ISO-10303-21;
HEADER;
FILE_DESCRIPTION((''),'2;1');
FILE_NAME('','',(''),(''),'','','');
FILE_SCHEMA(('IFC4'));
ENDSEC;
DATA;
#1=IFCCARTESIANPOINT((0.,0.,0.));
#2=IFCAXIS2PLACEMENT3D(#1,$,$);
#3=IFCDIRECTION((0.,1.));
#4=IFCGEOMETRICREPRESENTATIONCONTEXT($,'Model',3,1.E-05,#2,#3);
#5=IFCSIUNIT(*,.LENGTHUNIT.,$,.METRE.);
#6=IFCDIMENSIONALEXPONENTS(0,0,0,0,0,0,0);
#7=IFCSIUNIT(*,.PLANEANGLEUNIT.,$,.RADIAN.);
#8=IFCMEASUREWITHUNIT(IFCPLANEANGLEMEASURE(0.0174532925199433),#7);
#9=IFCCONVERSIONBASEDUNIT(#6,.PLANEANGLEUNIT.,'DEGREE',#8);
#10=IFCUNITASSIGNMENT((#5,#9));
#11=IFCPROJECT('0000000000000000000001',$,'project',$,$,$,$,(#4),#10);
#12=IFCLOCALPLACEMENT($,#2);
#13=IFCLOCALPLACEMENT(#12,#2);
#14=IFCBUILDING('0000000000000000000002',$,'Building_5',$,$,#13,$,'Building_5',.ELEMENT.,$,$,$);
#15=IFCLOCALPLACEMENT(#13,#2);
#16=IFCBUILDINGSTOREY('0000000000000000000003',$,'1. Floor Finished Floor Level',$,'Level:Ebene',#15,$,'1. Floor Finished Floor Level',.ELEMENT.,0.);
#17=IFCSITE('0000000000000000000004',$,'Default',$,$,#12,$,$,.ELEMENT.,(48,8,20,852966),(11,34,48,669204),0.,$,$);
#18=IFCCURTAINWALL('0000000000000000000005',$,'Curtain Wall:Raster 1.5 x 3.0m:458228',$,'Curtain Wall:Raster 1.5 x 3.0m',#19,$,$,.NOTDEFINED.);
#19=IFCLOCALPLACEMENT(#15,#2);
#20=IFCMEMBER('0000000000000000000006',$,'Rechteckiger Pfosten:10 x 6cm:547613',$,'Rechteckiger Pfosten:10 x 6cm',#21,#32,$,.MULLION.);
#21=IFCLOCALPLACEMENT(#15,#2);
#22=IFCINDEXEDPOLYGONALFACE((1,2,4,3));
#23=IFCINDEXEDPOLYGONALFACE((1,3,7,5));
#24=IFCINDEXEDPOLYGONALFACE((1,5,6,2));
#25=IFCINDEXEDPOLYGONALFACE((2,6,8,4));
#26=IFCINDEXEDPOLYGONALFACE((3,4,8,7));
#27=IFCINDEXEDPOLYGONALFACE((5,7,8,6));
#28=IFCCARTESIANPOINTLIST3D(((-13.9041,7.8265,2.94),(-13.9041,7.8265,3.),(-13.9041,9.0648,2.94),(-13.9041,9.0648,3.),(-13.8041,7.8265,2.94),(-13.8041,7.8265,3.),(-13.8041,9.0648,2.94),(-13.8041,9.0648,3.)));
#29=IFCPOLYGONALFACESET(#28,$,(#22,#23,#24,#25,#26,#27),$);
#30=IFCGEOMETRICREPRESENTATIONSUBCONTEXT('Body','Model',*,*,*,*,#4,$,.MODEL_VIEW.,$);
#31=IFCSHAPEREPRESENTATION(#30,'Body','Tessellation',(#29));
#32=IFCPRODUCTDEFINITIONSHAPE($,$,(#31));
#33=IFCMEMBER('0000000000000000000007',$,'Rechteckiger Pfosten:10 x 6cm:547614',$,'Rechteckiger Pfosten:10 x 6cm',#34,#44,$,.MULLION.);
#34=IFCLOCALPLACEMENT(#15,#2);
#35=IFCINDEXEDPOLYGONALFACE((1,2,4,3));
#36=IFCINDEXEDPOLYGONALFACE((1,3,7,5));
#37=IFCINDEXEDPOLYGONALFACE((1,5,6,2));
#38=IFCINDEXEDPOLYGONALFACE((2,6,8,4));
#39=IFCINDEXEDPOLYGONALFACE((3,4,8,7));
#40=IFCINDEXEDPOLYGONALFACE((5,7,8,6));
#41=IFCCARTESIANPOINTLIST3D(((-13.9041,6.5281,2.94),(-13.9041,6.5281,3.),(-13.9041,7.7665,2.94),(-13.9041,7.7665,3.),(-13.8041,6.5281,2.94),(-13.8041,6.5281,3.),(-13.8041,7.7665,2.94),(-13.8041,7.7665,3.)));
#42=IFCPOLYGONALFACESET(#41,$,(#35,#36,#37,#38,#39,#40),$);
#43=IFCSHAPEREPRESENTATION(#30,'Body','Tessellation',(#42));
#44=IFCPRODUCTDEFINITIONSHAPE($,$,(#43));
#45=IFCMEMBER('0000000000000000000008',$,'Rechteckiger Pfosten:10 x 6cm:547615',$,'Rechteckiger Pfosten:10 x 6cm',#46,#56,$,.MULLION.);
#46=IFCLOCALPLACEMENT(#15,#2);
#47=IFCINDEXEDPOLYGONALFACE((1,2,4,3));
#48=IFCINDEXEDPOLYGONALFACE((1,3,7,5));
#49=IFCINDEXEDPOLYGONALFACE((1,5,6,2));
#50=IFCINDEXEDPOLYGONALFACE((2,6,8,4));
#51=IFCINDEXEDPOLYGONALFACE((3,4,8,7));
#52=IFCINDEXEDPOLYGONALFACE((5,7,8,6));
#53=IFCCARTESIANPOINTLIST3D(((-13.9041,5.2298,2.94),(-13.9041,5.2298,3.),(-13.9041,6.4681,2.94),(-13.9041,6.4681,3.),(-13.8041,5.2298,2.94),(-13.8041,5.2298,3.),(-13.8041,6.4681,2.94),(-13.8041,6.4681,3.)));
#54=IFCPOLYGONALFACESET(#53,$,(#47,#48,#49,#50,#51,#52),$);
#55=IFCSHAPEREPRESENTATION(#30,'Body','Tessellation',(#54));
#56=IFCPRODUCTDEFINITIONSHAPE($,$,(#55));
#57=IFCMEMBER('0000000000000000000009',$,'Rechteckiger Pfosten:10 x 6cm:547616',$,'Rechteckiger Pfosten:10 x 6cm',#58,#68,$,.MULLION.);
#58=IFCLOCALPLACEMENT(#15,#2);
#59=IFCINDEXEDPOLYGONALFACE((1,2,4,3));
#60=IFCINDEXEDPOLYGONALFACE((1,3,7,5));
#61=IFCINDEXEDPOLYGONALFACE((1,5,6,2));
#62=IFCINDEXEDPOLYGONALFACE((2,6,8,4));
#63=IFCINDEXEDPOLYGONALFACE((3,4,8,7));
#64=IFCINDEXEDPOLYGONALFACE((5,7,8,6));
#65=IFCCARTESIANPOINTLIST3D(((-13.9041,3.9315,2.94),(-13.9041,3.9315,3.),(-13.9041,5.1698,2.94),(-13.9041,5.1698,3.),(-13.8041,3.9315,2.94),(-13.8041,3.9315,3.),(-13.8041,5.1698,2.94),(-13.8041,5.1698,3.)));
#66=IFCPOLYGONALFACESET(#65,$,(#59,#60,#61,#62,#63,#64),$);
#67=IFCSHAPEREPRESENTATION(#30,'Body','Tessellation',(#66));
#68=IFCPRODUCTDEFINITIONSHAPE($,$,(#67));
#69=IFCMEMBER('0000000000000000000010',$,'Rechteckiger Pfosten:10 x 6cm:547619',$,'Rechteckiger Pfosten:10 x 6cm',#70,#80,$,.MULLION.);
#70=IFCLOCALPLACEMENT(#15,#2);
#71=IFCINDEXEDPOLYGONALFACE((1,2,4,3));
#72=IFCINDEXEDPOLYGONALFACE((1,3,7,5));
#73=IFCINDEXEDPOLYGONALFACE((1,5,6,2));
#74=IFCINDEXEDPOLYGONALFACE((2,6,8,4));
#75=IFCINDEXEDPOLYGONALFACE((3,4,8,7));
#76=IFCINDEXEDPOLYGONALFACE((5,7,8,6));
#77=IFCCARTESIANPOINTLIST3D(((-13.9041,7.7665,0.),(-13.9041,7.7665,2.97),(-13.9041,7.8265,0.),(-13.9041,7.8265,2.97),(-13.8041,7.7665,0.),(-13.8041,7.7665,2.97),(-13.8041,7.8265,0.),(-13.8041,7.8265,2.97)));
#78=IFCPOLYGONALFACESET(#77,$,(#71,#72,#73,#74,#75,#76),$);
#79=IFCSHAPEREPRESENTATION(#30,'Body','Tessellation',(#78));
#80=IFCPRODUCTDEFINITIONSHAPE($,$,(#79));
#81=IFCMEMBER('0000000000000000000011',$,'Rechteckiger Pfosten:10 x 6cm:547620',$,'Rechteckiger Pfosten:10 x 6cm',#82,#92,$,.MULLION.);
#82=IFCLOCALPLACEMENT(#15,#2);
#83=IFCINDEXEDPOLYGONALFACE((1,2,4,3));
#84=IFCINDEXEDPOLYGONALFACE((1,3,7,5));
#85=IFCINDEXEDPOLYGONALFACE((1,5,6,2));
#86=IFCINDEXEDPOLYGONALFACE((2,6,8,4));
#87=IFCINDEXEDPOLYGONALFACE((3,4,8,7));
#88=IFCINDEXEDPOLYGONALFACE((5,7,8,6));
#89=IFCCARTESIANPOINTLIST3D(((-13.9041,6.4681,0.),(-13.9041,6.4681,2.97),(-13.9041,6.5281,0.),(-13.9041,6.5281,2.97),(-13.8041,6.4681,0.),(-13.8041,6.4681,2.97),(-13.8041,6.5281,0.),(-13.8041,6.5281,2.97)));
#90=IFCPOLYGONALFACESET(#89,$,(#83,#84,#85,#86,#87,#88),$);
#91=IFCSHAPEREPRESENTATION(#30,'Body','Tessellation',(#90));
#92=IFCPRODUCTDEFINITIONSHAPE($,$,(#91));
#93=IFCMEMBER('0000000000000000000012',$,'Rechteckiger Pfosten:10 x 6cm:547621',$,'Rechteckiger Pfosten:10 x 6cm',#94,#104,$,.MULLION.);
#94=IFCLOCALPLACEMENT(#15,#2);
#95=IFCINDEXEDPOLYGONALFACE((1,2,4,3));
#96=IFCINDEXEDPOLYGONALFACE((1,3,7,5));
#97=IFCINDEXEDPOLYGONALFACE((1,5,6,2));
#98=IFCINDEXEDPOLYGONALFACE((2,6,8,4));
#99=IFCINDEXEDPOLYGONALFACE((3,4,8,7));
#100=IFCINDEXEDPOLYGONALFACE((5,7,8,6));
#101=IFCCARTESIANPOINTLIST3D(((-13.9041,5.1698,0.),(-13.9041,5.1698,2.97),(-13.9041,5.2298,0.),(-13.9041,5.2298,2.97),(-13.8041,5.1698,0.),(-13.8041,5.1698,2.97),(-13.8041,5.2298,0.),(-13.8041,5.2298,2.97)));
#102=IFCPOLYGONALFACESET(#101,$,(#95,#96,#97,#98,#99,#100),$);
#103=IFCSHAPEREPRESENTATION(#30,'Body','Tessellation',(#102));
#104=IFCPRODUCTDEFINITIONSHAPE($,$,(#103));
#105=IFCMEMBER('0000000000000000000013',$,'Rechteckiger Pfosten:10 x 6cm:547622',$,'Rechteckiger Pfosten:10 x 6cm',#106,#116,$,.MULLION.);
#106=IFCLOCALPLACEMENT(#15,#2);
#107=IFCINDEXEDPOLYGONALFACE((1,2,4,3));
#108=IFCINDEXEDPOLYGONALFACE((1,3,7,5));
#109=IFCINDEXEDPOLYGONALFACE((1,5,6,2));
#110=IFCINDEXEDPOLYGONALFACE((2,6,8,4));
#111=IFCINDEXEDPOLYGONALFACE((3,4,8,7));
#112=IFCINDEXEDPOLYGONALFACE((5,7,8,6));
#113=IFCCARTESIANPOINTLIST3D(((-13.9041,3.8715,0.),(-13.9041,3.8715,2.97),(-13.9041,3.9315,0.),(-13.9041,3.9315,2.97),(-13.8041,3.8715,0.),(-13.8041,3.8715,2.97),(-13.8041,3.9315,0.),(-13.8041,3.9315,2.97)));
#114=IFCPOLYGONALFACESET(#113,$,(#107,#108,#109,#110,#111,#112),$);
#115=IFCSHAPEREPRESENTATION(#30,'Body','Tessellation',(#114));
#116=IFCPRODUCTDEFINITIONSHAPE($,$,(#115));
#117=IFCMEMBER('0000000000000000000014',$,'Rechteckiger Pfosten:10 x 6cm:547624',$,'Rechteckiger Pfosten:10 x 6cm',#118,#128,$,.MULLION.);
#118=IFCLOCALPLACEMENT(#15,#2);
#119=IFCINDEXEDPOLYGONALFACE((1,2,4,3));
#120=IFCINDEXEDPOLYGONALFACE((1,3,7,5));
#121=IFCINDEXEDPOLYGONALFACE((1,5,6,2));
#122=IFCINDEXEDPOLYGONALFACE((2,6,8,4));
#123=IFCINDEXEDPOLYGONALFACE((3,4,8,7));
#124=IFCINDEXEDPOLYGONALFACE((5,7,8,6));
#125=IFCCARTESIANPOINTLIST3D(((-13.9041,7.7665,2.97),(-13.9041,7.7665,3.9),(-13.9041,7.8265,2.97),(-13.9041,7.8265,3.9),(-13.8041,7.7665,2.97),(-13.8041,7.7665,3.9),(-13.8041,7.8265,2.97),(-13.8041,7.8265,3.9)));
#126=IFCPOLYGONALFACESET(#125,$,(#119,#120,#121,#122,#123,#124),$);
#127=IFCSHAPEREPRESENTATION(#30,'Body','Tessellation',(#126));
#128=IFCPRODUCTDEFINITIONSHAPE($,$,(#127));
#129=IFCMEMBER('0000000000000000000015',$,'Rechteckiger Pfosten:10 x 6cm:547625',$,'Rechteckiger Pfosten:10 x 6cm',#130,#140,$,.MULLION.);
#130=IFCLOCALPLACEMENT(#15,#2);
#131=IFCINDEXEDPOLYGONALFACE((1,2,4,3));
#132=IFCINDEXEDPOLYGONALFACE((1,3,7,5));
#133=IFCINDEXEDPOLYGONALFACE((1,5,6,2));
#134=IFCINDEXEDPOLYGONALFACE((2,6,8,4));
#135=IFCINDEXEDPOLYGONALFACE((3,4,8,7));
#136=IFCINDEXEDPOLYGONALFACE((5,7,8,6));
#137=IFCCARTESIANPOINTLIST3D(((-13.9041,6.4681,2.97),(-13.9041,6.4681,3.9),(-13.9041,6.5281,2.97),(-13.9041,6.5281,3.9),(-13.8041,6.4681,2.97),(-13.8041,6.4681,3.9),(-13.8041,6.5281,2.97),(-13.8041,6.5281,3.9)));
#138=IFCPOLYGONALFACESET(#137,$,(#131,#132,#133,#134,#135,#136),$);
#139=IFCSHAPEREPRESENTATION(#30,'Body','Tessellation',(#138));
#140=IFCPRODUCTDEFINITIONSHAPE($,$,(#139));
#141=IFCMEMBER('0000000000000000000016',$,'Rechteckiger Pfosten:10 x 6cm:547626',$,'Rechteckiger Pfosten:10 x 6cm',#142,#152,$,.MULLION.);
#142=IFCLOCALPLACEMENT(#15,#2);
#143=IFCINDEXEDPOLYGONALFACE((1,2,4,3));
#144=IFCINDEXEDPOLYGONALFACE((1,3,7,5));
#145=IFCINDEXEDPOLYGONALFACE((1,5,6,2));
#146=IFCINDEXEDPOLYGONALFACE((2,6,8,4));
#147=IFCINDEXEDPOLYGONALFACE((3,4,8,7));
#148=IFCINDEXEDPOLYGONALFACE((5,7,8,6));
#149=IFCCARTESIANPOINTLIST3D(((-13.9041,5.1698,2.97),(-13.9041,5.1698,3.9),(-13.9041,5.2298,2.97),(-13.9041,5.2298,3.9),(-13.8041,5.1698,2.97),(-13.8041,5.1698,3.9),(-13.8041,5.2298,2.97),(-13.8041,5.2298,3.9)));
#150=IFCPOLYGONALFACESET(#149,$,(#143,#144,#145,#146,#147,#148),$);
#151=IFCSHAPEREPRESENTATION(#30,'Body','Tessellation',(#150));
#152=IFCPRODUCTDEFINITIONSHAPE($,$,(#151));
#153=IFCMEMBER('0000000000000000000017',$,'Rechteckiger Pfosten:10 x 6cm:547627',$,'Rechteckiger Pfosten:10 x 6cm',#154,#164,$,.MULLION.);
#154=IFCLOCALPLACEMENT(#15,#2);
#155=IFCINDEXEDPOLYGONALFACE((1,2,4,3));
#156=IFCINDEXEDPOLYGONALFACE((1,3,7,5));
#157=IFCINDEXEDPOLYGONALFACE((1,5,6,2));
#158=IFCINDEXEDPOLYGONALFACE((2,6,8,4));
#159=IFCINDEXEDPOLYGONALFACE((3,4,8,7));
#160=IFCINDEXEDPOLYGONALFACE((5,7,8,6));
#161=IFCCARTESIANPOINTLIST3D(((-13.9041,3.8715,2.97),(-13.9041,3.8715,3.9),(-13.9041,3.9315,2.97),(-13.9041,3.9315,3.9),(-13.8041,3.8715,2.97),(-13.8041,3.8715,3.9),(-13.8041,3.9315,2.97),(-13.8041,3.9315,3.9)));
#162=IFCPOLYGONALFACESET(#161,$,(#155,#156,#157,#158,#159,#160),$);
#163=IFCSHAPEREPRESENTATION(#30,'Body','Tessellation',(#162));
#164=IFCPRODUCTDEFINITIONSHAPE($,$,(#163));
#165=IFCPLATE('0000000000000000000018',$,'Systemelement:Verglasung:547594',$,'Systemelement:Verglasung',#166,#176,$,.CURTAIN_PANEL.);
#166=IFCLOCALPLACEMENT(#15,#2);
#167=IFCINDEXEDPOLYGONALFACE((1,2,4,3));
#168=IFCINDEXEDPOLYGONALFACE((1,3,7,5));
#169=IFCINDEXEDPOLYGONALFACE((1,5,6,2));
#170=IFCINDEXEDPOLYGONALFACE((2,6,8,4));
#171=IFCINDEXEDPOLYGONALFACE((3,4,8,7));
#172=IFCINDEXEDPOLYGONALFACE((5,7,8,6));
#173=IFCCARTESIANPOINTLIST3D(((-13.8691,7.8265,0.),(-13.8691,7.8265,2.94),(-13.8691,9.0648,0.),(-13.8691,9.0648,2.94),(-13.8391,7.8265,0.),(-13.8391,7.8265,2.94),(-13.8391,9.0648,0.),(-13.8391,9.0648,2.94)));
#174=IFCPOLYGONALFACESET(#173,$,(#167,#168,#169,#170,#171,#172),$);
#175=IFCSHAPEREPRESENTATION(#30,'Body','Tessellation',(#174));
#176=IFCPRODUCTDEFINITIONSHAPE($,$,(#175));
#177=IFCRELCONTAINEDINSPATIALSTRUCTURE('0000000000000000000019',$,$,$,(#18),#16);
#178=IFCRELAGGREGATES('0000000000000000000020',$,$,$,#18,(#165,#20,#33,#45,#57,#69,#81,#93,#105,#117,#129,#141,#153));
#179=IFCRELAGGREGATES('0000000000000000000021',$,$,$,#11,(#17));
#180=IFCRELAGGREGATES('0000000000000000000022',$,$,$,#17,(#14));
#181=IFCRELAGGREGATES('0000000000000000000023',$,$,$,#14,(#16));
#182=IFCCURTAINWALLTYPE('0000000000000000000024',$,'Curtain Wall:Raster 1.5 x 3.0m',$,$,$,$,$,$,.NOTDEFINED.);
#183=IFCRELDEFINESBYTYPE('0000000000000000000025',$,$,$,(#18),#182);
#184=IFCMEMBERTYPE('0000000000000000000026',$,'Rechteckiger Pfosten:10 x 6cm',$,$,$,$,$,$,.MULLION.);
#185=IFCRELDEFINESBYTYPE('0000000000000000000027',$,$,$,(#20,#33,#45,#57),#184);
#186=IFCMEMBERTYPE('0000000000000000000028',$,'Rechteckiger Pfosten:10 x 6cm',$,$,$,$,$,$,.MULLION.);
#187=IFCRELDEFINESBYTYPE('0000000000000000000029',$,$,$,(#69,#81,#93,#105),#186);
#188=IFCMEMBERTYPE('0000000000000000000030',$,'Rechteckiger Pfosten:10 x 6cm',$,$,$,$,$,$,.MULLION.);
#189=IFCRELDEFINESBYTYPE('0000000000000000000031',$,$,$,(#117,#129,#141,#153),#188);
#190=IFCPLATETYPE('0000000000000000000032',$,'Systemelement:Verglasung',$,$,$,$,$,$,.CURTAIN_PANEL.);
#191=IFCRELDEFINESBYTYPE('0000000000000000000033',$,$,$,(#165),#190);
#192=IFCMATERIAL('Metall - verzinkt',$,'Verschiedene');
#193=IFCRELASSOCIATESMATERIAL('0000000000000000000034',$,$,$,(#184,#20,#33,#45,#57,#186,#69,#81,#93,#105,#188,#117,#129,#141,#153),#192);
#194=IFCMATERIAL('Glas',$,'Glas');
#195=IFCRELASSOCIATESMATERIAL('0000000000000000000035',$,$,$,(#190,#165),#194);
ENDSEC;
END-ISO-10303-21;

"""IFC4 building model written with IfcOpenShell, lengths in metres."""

from ifc_helpers import new_model, entity, si_unit, converted_unit, direction, frame, origin, place, context, subcontext, project, spatial, indexed_curve, outline, extrude, source, transform, mapped, material, type_object, type_shapes, element, aggregate, save


model = new_model("IFC4")

# Units and contexts
model_context = context("Model", 3, precision=1e-05, world=origin(), true_north=direction((0.0, 1.0)))
body_context = subcontext(model_context, "Body", "Model", "MODEL_VIEW")
ifc_project = project(units=[si_unit("LENGTHUNIT", "METRE"), converted_unit("PLANEANGLEUNIT", "DEGREE", entity("IfcPlaneAngleMeasure", 0.0174532925199433), si_unit("PLANEANGLEUNIT", "RADIAN"), dimensions=[0, 0, 0, 0, 0, 0, 0])], contexts=[model_context])

# Site, building, storey
site_placement = place(None, origin())
site = spatial("IfcSite", under=ifc_project, at=site_placement, Name="Default", CompositionType="ELEMENT", RefLatitude=(48, 8, 20, 852966), RefLongitude=(11, 34, 48, 669204), RefElevation=0.0)
building_placement = place(site_placement, origin())
building = spatial("IfcBuilding", under=site, at=building_placement, Name="Building_5", LongName="Building_5", CompositionType="ELEMENT")
storey_placement = place(building_placement, origin())
storey = spatial("IfcBuildingStorey", under=building, at=storey_placement, Name="1. Floor Finished Floor Level", ObjectType="Level:Ebene", LongName="1. Floor Finished Floor Level", CompositionType="ELEMENT", Elevation=0.0)

# Curtain wall, members, plate
curtain_wall_type = type_object("IfcCurtainWallType", Name="Curtain Wall:Raster 1.5 x 3.0m", PredefinedType="NOTDEFINED")
curtain_wall_placement = place(storey_placement, origin())
curtain_wall = element("IfcCurtainWall", 1, at=curtain_wall_placement, inside=storey, type_object=curtain_wall_type, Name="Curtain Wall:Raster 1.5 x 3.0m:458228", ObjectType="Curtain Wall:Raster 1.5 x 3.0m", PredefinedType="NOTDEFINED")
ifc_material_1 = material(Name="Metall - verzinkt", Category="Verschiedene")
member_type_1 = type_object("IfcMemberType", Name="Rechteckiger Pfosten:10 x 6cm", PredefinedType="MULLION", material=ifc_material_1)
shared_shape_1 = source(origin(), body_context, "Body", "SweptSolid", [
    extrude(outline(indexed_curve([(-0.03, -0.05), (0.03, -0.05), (0.03, 0.05), (-0.03, 0.05), (-0.03, -0.05)], self_intersect=False)), frame((0.0, 0.0, -1.2383), z_axis=(0.0, 0.0, 1.0), x_axis=(-1.0, 0.0, 0.0)), (0.0, 0.0, 1.0), 1.2383),
])
type_shapes(member_type_1, [shared_shape_1])
member_1_placement = place(curtain_wall_placement, frame((-13.8541, 7.8265, 2.97), z_axis=(0.0, -1.0, 0.0), x_axis=(0.0, 0.0, 1.0)))
member_1 = element("IfcMember", 2, at=member_1_placement, type_object=member_type_1, material=ifc_material_1, Name="Rechteckiger Pfosten:10 x 6cm:547613", ObjectType="Rechteckiger Pfosten:10 x 6cm", PredefinedType="MULLION", context=body_context, shape_type="MappedRepresentation", body=[
    mapped(shared_shape_1, transform((0.0, 0.0, 0.0), scale=1.0)),
])
member_2_placement = place(curtain_wall_placement, frame((-13.8541, 6.5281, 2.97), z_axis=(0.0, -1.0, 0.0), x_axis=(0.0, 0.0, 1.0)))
member_2 = element("IfcMember", 3, at=member_2_placement, type_object=member_type_1, material=ifc_material_1, Name="Rechteckiger Pfosten:10 x 6cm:547614", ObjectType="Rechteckiger Pfosten:10 x 6cm", PredefinedType="MULLION", context=body_context, shape_type="MappedRepresentation", body=[
    mapped(shared_shape_1, transform((0.0, 0.0, 0.0), scale=1.0)),
])
member_3_placement = place(curtain_wall_placement, frame((-13.8541, 5.2298, 2.97), z_axis=(0.0, -1.0, 0.0), x_axis=(0.0, 0.0, 1.0)))
member_3 = element("IfcMember", 4, at=member_3_placement, type_object=member_type_1, material=ifc_material_1, Name="Rechteckiger Pfosten:10 x 6cm:547615", ObjectType="Rechteckiger Pfosten:10 x 6cm", PredefinedType="MULLION", context=body_context, shape_type="MappedRepresentation", body=[
    mapped(shared_shape_1, transform((0.0, 0.0, 0.0), scale=1.0)),
])
member_4_placement = place(curtain_wall_placement, frame((-13.8541, 3.9315, 2.97), z_axis=(0.0, -1.0, 0.0), x_axis=(0.0, 0.0, 1.0)))
member_4 = element("IfcMember", 5, at=member_4_placement, type_object=member_type_1, material=ifc_material_1, Name="Rechteckiger Pfosten:10 x 6cm:547616", ObjectType="Rechteckiger Pfosten:10 x 6cm", PredefinedType="MULLION", context=body_context, shape_type="MappedRepresentation", body=[
    mapped(shared_shape_1, transform((0.0, 0.0, 0.0), scale=1.0)),
])
member_type_2 = type_object("IfcMemberType", Name="Rechteckiger Pfosten:10 x 6cm", PredefinedType="MULLION", material=ifc_material_1)
shared_shape_2 = source(origin(), body_context, "Body", "SweptSolid", [
    extrude(outline(indexed_curve([(-0.03, -0.05), (0.03, -0.05), (0.03, 0.05), (-0.03, 0.05), (-0.03, -0.05)], self_intersect=False)), frame((0.0, 0.0, -2.97), z_axis=(0.0, 0.0, 1.0), x_axis=(-1.0, 0.0, 0.0)), (0.0, 0.0, 1.0), 2.97),
])
type_shapes(member_type_2, [shared_shape_2])
member_5_placement = place(curtain_wall_placement, frame((-13.8541, 7.7965, 0.0), z_axis=(0.0, 0.0, -1.0), x_axis=(0.0, -1.0, 0.0)))
member_5 = element("IfcMember", 6, at=member_5_placement, type_object=member_type_2, material=ifc_material_1, Name="Rechteckiger Pfosten:10 x 6cm:547619", ObjectType="Rechteckiger Pfosten:10 x 6cm", PredefinedType="MULLION", context=body_context, shape_type="MappedRepresentation", body=[
    mapped(shared_shape_2, transform((0.0, 0.0, 0.0), scale=1.0)),
])
member_6_placement = place(curtain_wall_placement, frame((-13.8541, 6.4981, 0.0), z_axis=(0.0, 0.0, -1.0), x_axis=(0.0, -1.0, 0.0)))
member_6 = element("IfcMember", 7, at=member_6_placement, type_object=member_type_2, material=ifc_material_1, Name="Rechteckiger Pfosten:10 x 6cm:547620", ObjectType="Rechteckiger Pfosten:10 x 6cm", PredefinedType="MULLION", context=body_context, shape_type="MappedRepresentation", body=[
    mapped(shared_shape_2, transform((0.0, 0.0, 0.0), scale=1.0)),
])
member_7_placement = place(curtain_wall_placement, frame((-13.8541, 5.1998, 0.0), z_axis=(0.0, 0.0, -1.0), x_axis=(0.0, -1.0, 0.0)))
member_7 = element("IfcMember", 8, at=member_7_placement, type_object=member_type_2, material=ifc_material_1, Name="Rechteckiger Pfosten:10 x 6cm:547621", ObjectType="Rechteckiger Pfosten:10 x 6cm", PredefinedType="MULLION", context=body_context, shape_type="MappedRepresentation", body=[
    mapped(shared_shape_2, transform((0.0, 0.0, 0.0), scale=1.0)),
])
member_8_placement = place(curtain_wall_placement, frame((-13.8541, 3.9015, 0.0), z_axis=(0.0, 0.0, -1.0), x_axis=(0.0, -1.0, 0.0)))
member_8 = element("IfcMember", 9, at=member_8_placement, type_object=member_type_2, material=ifc_material_1, Name="Rechteckiger Pfosten:10 x 6cm:547622", ObjectType="Rechteckiger Pfosten:10 x 6cm", PredefinedType="MULLION", context=body_context, shape_type="MappedRepresentation", body=[
    mapped(shared_shape_2, transform((0.0, 0.0, 0.0), scale=1.0)),
])
member_type_3 = type_object("IfcMemberType", Name="Rechteckiger Pfosten:10 x 6cm", PredefinedType="MULLION", material=ifc_material_1)
shared_shape_3 = source(origin(), body_context, "Body", "SweptSolid", [
    extrude(outline(indexed_curve([(-0.03, -0.05), (0.03, -0.05), (0.03, 0.05), (-0.03, 0.05), (-0.03, -0.05)], self_intersect=False)), frame((0.0, 0.0, -0.93), z_axis=(0.0, 0.0, 1.0), x_axis=(-1.0, 0.0, 0.0)), (0.0, 0.0, 1.0), 0.93),
])
type_shapes(member_type_3, [shared_shape_3])
member_9_placement = place(curtain_wall_placement, frame((-13.8541, 7.7965, 2.97), z_axis=(0.0, 0.0, -1.0), x_axis=(0.0, -1.0, 0.0)))
member_9 = element("IfcMember", 10, at=member_9_placement, type_object=member_type_3, material=ifc_material_1, Name="Rechteckiger Pfosten:10 x 6cm:547624", ObjectType="Rechteckiger Pfosten:10 x 6cm", PredefinedType="MULLION", context=body_context, shape_type="MappedRepresentation", body=[
    mapped(shared_shape_3, transform((0.0, 0.0, 0.0), scale=1.0)),
])
member_10_placement = place(curtain_wall_placement, frame((-13.8541, 6.4981, 2.97), z_axis=(0.0, 0.0, -1.0), x_axis=(0.0, -1.0, 0.0)))
member_10 = element("IfcMember", 11, at=member_10_placement, type_object=member_type_3, material=ifc_material_1, Name="Rechteckiger Pfosten:10 x 6cm:547625", ObjectType="Rechteckiger Pfosten:10 x 6cm", PredefinedType="MULLION", context=body_context, shape_type="MappedRepresentation", body=[
    mapped(shared_shape_3, transform((0.0, 0.0, 0.0), scale=1.0)),
])
member_11_placement = place(curtain_wall_placement, frame((-13.8541, 5.1998, 2.97), z_axis=(0.0, 0.0, -1.0), x_axis=(0.0, -1.0, 0.0)))
member_11 = element("IfcMember", 12, at=member_11_placement, type_object=member_type_3, material=ifc_material_1, Name="Rechteckiger Pfosten:10 x 6cm:547626", ObjectType="Rechteckiger Pfosten:10 x 6cm", PredefinedType="MULLION", context=body_context, shape_type="MappedRepresentation", body=[
    mapped(shared_shape_3, transform((0.0, 0.0, 0.0), scale=1.0)),
])
member_12_placement = place(curtain_wall_placement, frame((-13.8541, 3.9015, 2.97), z_axis=(0.0, 0.0, -1.0), x_axis=(0.0, -1.0, 0.0)))
member_12 = element("IfcMember", 13, at=member_12_placement, type_object=member_type_3, material=ifc_material_1, Name="Rechteckiger Pfosten:10 x 6cm:547627", ObjectType="Rechteckiger Pfosten:10 x 6cm", PredefinedType="MULLION", context=body_context, shape_type="MappedRepresentation", body=[
    mapped(shared_shape_3, transform((0.0, 0.0, 0.0), scale=1.0)),
])
ifc_material_2 = material(Name="Glas", Category="Glas")
plate_type_1 = type_object("IfcPlateType", Name="Systemelement:Verglasung", PredefinedType="CURTAIN_PANEL", material=ifc_material_2)
shared_shape_4 = source(origin(), body_context, "Body", "SweptSolid", [
    extrude(outline(indexed_curve([(-0.015, -0.6192), (0.015, -0.6192), (0.015, 0.6192), (-0.015, 0.6192), (-0.015, -0.6192)], self_intersect=False)), frame((0.0, 0.0, 0.0), z_axis=(0.0, 0.0, 1.0), x_axis=(0.0, 1.0, 0.0)), (0.0, 0.0, 1.0), 2.94),
])
type_shapes(plate_type_1, [shared_shape_4])
plate_1_placement = place(curtain_wall_placement, frame((-13.8541, 8.4456, 0.0), z_axis=(0.0, 0.0, 1.0), x_axis=(0.0, -1.0, 0.0)))
plate_1 = element("IfcPlate", 14, at=plate_1_placement, type_object=plate_type_1, material=ifc_material_2, Name="Systemelement:Verglasung:547594", ObjectType="Systemelement:Verglasung", PredefinedType="CURTAIN_PANEL", context=body_context, shape_type="MappedRepresentation", body=[
    mapped(shared_shape_4, transform((0.0, 0.0, 0.0), scale=1.0)),
])
aggregate(curtain_wall, [plate_1, member_1, member_2, member_3, member_4, member_5, member_6, member_7, member_8, member_9, member_10, member_11, member_12])

save(model, "model.ifc")
